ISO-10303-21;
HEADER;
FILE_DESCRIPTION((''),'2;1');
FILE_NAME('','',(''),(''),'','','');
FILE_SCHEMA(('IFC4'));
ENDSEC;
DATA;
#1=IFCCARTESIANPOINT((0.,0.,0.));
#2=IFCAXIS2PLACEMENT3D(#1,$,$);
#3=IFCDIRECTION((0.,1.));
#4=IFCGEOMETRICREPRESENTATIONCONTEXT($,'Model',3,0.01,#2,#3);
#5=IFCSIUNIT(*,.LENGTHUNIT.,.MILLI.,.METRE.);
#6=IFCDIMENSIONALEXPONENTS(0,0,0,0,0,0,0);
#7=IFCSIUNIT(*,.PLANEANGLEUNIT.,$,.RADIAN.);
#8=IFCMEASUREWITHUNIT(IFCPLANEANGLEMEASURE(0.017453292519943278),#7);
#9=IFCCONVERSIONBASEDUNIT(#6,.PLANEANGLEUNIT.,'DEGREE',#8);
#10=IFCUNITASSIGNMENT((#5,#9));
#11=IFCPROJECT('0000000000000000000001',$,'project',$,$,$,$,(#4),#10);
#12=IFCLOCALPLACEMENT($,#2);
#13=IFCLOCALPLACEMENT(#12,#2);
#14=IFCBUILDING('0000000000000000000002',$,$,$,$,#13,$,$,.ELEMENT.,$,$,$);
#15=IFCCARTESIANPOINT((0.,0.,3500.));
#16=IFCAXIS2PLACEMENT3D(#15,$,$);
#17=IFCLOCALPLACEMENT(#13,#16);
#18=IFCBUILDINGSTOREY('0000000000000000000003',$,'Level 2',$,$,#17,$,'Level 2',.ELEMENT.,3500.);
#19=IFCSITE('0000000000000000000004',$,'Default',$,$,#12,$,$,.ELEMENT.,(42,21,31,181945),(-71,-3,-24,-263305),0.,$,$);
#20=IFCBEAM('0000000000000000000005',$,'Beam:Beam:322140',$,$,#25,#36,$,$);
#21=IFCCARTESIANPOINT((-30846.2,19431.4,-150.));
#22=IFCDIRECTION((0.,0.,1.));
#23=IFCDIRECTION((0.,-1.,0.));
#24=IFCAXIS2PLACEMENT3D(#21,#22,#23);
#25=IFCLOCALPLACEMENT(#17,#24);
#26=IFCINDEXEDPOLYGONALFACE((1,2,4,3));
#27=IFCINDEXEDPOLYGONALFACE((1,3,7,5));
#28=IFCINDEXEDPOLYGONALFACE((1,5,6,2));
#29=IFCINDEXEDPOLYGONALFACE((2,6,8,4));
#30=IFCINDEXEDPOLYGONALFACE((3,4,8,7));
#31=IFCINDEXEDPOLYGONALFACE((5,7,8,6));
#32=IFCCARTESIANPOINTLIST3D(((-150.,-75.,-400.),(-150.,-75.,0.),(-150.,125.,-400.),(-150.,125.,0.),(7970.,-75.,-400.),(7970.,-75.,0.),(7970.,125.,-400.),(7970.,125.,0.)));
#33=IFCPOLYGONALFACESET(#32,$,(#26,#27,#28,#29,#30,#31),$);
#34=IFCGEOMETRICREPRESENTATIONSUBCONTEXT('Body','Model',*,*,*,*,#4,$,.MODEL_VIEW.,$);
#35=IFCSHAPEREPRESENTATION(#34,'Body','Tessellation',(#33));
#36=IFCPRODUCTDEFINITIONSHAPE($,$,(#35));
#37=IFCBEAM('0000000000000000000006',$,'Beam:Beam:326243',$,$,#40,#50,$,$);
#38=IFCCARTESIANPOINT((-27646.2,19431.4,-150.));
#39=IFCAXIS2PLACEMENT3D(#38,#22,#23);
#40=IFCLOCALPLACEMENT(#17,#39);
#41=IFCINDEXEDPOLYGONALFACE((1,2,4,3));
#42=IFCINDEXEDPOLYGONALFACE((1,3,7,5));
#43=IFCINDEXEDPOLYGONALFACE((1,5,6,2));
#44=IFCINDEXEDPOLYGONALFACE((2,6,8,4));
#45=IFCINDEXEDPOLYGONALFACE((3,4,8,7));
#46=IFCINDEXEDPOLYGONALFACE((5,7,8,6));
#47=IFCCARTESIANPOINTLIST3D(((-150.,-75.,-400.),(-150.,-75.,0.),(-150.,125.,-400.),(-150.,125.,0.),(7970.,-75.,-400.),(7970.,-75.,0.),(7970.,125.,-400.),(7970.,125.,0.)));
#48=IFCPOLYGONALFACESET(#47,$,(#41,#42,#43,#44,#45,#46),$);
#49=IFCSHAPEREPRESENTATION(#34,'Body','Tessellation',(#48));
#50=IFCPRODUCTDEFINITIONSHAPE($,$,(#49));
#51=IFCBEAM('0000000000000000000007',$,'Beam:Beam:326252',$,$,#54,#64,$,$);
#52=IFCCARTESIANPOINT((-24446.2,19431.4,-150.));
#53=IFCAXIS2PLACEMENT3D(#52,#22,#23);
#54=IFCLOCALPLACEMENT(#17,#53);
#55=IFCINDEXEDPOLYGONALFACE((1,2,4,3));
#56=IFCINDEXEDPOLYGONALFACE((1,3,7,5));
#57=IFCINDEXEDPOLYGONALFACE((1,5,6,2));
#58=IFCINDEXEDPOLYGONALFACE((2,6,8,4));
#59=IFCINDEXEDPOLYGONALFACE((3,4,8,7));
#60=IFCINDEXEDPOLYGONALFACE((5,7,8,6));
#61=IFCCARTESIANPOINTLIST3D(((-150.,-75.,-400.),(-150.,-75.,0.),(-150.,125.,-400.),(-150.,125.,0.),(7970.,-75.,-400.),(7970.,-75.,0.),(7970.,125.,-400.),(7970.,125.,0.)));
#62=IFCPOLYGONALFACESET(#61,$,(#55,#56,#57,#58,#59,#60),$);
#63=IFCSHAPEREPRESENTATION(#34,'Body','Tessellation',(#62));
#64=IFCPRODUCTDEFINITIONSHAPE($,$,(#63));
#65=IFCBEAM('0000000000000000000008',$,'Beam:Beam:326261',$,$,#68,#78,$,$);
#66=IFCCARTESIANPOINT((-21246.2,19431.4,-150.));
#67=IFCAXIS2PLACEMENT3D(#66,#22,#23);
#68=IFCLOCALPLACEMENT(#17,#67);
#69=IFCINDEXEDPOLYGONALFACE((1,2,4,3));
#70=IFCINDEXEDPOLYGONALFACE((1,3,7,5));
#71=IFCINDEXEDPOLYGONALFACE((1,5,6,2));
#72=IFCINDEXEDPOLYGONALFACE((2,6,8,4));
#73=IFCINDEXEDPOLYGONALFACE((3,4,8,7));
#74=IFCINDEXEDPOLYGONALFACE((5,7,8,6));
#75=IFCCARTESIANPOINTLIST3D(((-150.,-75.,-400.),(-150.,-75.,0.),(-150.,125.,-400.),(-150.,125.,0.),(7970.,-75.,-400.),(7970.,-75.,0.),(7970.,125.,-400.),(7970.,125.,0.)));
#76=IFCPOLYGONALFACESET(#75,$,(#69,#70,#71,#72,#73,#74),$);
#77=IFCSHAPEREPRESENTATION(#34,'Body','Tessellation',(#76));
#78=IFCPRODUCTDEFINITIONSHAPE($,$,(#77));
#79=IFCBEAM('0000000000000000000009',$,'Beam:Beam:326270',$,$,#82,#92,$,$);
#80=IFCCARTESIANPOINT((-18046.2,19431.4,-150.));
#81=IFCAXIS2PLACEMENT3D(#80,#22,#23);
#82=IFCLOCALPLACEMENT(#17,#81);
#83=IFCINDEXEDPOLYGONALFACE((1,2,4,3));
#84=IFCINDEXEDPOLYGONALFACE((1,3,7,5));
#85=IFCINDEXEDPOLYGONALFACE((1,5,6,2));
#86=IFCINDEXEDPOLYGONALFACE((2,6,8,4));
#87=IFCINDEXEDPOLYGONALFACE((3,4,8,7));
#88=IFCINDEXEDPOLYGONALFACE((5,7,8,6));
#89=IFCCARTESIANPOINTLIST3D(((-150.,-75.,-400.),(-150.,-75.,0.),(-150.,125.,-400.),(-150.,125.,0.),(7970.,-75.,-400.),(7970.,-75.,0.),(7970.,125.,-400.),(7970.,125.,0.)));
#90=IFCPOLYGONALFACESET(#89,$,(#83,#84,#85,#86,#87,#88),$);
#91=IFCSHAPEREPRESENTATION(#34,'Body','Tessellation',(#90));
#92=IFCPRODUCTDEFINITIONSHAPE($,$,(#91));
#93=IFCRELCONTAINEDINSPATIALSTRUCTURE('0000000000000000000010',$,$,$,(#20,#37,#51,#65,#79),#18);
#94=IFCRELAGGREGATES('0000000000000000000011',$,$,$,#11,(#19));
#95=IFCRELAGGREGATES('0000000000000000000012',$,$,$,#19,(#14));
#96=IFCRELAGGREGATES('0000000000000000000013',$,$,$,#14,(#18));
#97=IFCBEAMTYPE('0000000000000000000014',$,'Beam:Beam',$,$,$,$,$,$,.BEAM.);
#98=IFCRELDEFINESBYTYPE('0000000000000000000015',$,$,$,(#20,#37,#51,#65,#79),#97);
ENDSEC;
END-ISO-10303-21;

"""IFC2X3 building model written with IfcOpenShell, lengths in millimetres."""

from ifc_helpers import new_model, entity, si_unit, converted_unit, direction, frame, frame_2d, origin, place, context, subcontext, project, spatial, rectangle, extrude, type_object, element, save


model = new_model("IFC2X3")

# Units and contexts
model_context = context("Model", 3, precision=0.01, world=origin(), true_north=direction((0.0, 1.0)))
body_context = subcontext(model_context, "Body", "Model", "MODEL_VIEW")
ifc_project = project(units=[si_unit("LENGTHUNIT", "METRE", prefix="MILLI"), converted_unit("PLANEANGLEUNIT", "DEGREE", entity("IfcPlaneAngleMeasure", 0.017453292519943278), si_unit("PLANEANGLEUNIT", "RADIAN"), dimensions=[0, 0, 0, 0, 0, 0, 0])], contexts=[model_context])

# Site, building, storey
site_placement = place(None, origin())
site = spatial("IfcSite", under=ifc_project, at=site_placement, Name="Default", CompositionType="ELEMENT", RefLatitude=(42, 21, 31, 181945), RefLongitude=(-71, -3, -24, -263305), RefElevation=0.0)
building_placement = place(site_placement, origin())
building = spatial("IfcBuilding", under=site, at=building_placement, CompositionType="ELEMENT")
storey_placement = place(building_placement, frame((0.0, 0.0, 3500.0)))
storey = spatial("IfcBuildingStorey", under=building, at=storey_placement, Name="Level 2", LongName="Level 2", CompositionType="ELEMENT", Elevation=3500.0)

# Beams
beam_type = type_object("IfcBeamType", Name="Beam:Beam", PredefinedType="BEAM")
beam_1_placement = place(storey_placement, frame((-30846.2, 19431.4, -150.0), z_axis=(0.0, 0.0, 1.0), x_axis=(0.0, -1.0, 0.0)))
element("IfcBeam", 1, at=beam_1_placement, inside=storey, type_object=beam_type, Name="Beam:Beam:322140", context=body_context, shape_type="SweptSolid", body=[
    extrude(rectangle(XDim=400.0, YDim=200.0, at=frame_2d((0.0, 0.0), x_axis=(1.0, 0.0))), frame((-150.0, 25.0, -200.0), z_axis=(1.0, 0.0, 0.0), x_axis=(0.0, 0.0, -1.0)), (0.0, 0.0, 1.0), 8120.0),
])
beam_2_placement = place(storey_placement, frame((-27646.2, 19431.4, -150.0), z_axis=(0.0, 0.0, 1.0), x_axis=(0.0, -1.0, 0.0)))
element("IfcBeam", 2, at=beam_2_placement, inside=storey, type_object=beam_type, Name="Beam:Beam:326243", context=body_context, shape_type="SweptSolid", body=[
    extrude(rectangle(XDim=400.0, YDim=200.0, at=frame_2d((0.0, 0.0), x_axis=(1.0, 0.0))), frame((-150.0, 25.0, -200.0), z_axis=(1.0, 0.0, 0.0), x_axis=(0.0, 0.0, -1.0)), (0.0, 0.0, 1.0), 8120.0),
])
for number, where, z_axis, x_axis, name in (
    (3, (-24446.2, 19431.4, -150.0), (0.0, 0.0, 1.0), (0.0, -1.0, 0.0), "Beam:Beam:326252"),
    (4, (-21246.2, 19431.4, -150.0), (0.0, 0.0, 1.0), (0.0, -1.0, 0.0), "Beam:Beam:326261"),
):
    element("IfcBeam", number, at=place(storey_placement, frame(where, z_axis=z_axis, x_axis=x_axis)), inside=storey, type_object=beam_type, Name=name, context=body_context, shape_type="SweptSolid", body=[
        extrude(rectangle(XDim=400.0, YDim=200.0, at=frame_2d((0.0, 0.0), x_axis=(1.0, 0.0))), frame((-150.0, 25.0, -200.0), z_axis=(1.0, 0.0, 0.0), x_axis=(0.0, 0.0, -1.0)), (0.0, 0.0, 1.0), 8120.0),
    ])
beam_3_placement = place(storey_placement, frame((-18046.2, 19431.4, -150.0), z_axis=(0.0, 0.0, 1.0), x_axis=(0.0, -1.0, 0.0)))
element("IfcBeam", 5, at=beam_3_placement, inside=storey, type_object=beam_type, Name="Beam:Beam:326270", context=body_context, shape_type="SweptSolid", body=[
    extrude(rectangle(XDim=400.0, YDim=200.0, at=frame_2d((0.0, 0.0), x_axis=(1.0, 0.0))), frame((-150.0, 25.0, -200.0), z_axis=(1.0, 0.0, 0.0), x_axis=(0.0, 0.0, -1.0)), (0.0, 0.0, 1.0), 8120.0),
])

save(model, "model.ifc")
